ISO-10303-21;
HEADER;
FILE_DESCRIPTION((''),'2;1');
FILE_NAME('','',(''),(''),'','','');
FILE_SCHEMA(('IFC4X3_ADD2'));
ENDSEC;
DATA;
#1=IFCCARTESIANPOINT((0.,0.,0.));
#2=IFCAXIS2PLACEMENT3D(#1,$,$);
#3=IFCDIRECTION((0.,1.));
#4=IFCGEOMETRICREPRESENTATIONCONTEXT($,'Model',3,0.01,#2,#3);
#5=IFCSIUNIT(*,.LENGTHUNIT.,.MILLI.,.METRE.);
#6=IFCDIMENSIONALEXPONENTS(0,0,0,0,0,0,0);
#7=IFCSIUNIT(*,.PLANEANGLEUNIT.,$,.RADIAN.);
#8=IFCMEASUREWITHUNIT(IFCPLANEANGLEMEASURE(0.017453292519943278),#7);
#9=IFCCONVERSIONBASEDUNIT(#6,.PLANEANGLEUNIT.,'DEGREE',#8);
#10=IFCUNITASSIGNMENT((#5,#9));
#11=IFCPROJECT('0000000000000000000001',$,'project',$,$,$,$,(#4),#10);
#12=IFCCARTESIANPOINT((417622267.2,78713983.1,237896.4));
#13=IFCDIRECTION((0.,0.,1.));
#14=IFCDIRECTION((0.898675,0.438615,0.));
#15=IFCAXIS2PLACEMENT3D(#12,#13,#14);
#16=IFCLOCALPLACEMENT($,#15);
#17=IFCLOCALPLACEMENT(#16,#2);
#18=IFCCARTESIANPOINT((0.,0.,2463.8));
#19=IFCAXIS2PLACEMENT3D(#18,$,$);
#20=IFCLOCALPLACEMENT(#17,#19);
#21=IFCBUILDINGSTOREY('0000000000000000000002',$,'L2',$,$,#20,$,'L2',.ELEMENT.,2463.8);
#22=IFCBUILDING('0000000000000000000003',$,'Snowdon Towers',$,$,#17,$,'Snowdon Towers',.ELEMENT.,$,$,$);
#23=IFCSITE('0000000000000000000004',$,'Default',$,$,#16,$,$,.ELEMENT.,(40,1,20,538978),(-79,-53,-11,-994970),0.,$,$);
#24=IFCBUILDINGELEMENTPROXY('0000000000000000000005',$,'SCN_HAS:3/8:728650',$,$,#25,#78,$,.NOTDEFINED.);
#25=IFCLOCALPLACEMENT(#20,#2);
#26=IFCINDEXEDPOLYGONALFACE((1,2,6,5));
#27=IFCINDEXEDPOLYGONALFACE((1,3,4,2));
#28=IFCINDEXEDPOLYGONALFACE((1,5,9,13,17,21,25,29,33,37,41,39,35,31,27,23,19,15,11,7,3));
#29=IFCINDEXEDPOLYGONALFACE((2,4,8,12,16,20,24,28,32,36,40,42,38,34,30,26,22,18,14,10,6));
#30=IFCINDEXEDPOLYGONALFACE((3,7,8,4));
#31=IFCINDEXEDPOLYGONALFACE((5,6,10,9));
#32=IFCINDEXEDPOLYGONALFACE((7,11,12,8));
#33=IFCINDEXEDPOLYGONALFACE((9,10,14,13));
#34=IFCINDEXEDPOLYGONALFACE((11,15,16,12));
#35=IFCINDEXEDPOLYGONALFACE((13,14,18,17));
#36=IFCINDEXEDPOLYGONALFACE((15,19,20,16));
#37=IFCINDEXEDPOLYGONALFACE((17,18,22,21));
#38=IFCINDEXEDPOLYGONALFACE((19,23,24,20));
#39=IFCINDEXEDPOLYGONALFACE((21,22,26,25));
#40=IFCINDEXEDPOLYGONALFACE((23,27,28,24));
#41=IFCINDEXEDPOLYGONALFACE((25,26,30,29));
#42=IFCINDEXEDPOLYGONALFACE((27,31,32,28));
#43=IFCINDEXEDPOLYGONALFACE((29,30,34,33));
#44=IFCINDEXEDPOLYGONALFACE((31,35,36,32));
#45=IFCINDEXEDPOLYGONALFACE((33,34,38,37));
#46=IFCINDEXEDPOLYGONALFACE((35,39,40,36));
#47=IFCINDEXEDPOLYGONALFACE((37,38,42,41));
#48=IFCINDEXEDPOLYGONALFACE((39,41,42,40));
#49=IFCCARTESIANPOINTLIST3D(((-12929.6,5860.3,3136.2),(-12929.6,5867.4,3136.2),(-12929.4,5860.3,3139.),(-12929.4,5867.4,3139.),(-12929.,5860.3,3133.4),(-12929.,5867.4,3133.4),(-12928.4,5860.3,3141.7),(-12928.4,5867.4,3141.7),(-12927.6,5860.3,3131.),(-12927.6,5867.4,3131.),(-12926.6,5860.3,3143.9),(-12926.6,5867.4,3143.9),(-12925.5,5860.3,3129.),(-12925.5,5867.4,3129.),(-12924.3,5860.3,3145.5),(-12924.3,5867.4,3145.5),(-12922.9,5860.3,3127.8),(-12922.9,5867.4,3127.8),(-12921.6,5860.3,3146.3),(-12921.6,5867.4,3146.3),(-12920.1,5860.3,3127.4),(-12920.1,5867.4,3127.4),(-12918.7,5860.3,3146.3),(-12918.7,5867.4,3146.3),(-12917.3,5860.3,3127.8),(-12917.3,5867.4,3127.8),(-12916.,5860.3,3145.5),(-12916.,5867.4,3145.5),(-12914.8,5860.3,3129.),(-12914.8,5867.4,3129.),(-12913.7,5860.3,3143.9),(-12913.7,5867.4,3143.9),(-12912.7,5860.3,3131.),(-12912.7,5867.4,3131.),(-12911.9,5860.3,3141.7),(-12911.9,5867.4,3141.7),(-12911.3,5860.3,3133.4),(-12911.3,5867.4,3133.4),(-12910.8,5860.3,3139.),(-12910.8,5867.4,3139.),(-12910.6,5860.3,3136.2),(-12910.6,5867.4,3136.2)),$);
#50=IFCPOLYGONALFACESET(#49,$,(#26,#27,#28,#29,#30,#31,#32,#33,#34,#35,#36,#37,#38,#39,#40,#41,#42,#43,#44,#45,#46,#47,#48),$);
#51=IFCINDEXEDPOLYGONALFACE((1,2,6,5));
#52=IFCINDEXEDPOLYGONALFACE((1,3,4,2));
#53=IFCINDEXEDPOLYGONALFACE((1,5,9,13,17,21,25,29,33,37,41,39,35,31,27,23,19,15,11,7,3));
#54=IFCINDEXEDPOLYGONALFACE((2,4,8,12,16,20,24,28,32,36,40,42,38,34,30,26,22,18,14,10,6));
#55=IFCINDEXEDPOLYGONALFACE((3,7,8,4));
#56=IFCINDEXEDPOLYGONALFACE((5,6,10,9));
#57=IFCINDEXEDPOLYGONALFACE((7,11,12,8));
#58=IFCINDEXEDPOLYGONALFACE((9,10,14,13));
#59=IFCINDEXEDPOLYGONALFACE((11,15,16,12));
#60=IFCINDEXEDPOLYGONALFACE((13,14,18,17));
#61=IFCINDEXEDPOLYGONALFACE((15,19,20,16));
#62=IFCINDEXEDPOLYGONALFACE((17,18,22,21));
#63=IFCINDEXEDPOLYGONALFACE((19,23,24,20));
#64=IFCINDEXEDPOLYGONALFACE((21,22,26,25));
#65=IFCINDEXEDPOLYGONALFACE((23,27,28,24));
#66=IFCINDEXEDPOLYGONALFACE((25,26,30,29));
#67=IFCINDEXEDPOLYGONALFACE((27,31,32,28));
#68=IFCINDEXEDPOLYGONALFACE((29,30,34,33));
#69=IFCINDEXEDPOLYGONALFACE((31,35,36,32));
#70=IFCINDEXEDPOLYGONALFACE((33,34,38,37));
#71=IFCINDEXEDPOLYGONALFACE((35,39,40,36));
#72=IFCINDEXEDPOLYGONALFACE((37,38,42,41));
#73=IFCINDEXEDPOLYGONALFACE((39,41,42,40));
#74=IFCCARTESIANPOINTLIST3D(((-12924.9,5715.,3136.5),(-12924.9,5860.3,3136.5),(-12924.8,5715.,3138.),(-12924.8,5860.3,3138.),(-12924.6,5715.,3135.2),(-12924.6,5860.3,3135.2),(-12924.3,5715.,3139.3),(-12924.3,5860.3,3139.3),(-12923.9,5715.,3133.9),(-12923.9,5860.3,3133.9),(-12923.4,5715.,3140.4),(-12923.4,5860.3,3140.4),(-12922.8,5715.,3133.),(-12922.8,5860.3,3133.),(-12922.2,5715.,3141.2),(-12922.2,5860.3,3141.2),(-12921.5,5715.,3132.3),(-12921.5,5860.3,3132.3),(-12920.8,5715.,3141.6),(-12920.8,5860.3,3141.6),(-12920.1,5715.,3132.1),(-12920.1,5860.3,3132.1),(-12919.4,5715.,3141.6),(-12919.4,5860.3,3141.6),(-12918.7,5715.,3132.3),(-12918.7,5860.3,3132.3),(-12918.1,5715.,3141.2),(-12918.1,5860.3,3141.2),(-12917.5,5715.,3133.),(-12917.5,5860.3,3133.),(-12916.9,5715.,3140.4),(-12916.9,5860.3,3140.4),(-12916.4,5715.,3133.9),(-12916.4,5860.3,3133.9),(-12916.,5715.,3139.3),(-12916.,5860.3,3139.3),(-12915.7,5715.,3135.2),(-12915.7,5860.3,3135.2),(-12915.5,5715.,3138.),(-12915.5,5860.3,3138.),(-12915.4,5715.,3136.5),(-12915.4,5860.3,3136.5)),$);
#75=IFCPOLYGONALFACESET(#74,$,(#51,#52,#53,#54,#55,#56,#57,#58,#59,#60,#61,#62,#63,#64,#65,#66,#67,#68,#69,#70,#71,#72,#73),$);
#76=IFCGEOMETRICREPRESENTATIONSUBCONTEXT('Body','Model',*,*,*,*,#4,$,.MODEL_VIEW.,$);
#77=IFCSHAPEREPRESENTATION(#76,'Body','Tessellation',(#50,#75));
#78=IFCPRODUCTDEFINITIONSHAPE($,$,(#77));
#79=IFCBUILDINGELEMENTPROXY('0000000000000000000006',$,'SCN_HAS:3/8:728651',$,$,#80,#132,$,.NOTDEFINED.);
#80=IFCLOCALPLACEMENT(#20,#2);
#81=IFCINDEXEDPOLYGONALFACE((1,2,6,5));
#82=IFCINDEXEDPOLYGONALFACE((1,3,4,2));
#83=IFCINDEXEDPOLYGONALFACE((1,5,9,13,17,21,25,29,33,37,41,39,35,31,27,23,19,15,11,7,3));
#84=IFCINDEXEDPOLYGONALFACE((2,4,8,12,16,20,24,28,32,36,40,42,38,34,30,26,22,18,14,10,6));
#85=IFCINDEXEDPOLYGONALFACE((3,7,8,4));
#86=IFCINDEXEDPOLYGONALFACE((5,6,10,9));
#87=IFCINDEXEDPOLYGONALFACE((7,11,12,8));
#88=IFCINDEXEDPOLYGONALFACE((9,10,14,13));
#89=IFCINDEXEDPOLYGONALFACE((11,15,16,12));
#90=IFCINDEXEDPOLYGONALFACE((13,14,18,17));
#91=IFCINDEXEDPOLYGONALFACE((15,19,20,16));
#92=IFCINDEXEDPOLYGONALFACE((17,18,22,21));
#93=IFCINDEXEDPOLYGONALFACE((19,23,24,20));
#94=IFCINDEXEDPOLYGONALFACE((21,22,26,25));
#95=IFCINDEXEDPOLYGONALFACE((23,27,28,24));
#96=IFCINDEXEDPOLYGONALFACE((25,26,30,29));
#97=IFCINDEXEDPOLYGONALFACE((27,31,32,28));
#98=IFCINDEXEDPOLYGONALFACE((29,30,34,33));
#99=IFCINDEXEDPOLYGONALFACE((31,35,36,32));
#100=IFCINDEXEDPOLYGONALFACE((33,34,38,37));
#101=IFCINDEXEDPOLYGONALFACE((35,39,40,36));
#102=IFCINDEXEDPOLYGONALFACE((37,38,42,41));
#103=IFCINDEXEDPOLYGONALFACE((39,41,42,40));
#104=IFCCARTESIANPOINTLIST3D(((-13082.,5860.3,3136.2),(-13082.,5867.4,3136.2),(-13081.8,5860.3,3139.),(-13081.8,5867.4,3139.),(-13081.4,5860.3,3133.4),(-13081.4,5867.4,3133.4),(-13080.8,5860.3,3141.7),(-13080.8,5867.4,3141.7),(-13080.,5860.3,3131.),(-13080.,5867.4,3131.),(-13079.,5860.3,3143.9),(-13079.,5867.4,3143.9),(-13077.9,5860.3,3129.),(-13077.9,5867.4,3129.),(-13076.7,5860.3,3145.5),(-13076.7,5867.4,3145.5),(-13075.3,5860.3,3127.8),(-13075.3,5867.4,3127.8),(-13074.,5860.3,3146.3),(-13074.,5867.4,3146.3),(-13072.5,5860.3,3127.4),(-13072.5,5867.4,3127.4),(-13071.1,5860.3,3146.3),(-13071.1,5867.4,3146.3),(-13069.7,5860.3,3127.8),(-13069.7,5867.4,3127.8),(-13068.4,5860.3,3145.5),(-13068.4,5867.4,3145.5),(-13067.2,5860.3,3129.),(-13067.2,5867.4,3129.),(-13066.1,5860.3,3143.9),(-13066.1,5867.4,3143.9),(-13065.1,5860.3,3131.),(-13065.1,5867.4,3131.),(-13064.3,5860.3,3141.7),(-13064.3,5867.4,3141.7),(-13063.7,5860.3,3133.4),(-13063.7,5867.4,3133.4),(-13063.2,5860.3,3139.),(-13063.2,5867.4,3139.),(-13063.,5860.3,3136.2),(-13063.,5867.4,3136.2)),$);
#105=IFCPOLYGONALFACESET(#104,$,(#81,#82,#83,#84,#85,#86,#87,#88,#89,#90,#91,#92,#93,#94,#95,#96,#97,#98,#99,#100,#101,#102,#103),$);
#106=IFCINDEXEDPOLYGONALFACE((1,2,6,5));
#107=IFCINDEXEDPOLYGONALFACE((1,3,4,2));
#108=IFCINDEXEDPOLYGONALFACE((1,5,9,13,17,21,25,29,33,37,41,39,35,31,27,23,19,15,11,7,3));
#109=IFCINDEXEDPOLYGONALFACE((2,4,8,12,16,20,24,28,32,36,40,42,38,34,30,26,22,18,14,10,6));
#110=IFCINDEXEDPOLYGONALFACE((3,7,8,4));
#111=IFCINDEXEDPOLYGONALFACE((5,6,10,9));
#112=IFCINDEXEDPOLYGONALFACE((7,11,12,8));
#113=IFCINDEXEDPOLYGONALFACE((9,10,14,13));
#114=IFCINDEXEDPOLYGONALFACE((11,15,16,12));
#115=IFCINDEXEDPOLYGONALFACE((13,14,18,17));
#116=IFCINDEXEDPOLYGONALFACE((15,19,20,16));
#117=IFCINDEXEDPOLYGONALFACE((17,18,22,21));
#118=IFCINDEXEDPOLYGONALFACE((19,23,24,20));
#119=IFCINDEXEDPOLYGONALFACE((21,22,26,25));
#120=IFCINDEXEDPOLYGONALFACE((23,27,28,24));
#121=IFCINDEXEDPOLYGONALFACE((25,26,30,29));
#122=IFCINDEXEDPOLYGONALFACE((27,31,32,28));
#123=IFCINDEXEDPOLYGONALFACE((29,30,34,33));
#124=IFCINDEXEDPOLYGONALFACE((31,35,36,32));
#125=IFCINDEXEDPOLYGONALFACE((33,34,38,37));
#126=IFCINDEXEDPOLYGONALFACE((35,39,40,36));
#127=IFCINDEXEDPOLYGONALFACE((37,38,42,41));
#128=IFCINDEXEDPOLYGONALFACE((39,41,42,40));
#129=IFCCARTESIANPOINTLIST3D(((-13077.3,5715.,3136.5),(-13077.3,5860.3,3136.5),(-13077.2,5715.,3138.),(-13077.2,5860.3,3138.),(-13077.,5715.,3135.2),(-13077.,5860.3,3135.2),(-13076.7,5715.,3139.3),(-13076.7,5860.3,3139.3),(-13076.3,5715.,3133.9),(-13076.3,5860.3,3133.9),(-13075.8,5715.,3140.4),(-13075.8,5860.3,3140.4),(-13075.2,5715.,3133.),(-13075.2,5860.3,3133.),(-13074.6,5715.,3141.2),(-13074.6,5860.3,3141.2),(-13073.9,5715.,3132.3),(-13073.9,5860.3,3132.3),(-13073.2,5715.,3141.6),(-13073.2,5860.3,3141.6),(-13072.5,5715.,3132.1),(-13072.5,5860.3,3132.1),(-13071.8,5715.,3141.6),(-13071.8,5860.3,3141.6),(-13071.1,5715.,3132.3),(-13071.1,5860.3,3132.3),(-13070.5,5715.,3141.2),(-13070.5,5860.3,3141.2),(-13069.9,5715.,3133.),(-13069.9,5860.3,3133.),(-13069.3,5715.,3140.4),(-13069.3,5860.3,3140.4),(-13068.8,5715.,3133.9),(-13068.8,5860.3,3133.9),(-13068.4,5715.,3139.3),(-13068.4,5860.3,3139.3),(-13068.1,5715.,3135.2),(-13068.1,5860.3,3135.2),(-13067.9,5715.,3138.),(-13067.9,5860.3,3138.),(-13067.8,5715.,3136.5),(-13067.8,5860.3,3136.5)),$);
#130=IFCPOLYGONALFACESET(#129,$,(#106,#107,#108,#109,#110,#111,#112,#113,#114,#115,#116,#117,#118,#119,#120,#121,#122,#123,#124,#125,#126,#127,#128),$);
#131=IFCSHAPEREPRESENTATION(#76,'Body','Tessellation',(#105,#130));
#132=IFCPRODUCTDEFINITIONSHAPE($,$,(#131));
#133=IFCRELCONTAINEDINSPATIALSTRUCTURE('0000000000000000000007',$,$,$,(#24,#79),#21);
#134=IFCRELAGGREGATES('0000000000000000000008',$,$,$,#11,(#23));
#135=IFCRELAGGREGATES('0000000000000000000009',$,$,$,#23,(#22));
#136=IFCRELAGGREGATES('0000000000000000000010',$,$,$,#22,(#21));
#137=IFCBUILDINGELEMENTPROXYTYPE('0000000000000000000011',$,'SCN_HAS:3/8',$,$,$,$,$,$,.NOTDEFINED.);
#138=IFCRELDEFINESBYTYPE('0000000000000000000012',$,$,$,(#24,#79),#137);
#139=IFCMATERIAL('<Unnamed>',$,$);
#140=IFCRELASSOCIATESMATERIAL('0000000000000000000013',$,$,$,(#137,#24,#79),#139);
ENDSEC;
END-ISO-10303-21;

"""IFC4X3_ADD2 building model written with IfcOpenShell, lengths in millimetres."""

from ifc_helpers import new_model, entity, si_unit, converted_unit, direction, frame, frame_2d, origin, place, context, subcontext, project, spatial, circle, extrude, source, transform, mapped, material, type_object, type_shapes, element, save


model = new_model("IFC4X3_ADD2")

# Units and contexts
model_context = context("Model", 3, precision=0.01, world=origin(), true_north=direction((0.0, 1.0)))
body_context = subcontext(model_context, "Body", "Model", "MODEL_VIEW")
ifc_project = project(units=[si_unit("LENGTHUNIT", "METRE", prefix="MILLI"), converted_unit("PLANEANGLEUNIT", "DEGREE", entity("IfcPlaneAngleMeasure", 0.017453292519943278), si_unit("PLANEANGLEUNIT", "RADIAN"), dimensions=[0, 0, 0, 0, 0, 0, 0])], contexts=[model_context])

# Site, building, storey
site_placement = place(None, frame((417622267.2, 78713983.1, 237896.4), z_axis=(0.0, 0.0, 1.0), x_axis=(0.898675, 0.438615, 0.0)))
site = spatial("IfcSite", under=ifc_project, at=site_placement, Name="Default", CompositionType="ELEMENT", RefLatitude=(40, 1, 20, 538978), RefLongitude=(-79, -53, -11, -994970), RefElevation=0.0)
building_placement = place(site_placement, origin())
building = spatial("IfcBuilding", under=site, at=building_placement, Name="Snowdon Towers", LongName="Snowdon Towers", CompositionType="ELEMENT")
storey_placement = place(building_placement, frame((0.0, 0.0, 2463.8)))
storey = spatial("IfcBuildingStorey", under=building, at=storey_placement, Name="L2", LongName="L2", CompositionType="ELEMENT", Elevation=2463.8)

# Building element proxies
ifc_material_1 = material(Name="<Unnamed>")
building_element_proxy_type_1 = type_object("IfcBuildingElementProxyType", Name="SCN_HAS:3/8", PredefinedType="NOTDEFINED", material=ifc_material_1)
shared_shape_1 = source(origin(), body_context, "Body", "SweptSolid", [
    extrude(circle(Radius=9.5, at=frame_2d((0.0, 0.0), x_axis=(1.0, 0.0))), frame((0.0, 0.0, -152.4), z_axis=(0.0, 0.0, 1.0), x_axis=(0.0, -1.0, 0.0)), (0.0, 0.0, 1.0), 7.1),
    extrude(circle(Radius=4.8, at=frame_2d((0.0, 0.0), x_axis=(1.0, 0.0))), frame((0.0, 0.0, -145.3), z_axis=(0.0, 0.0, 1.0), x_axis=(0.0, -1.0, 0.0)), (0.0, 0.0, 1.0), 145.3),
])
type_shapes(building_element_proxy_type_1, [shared_shape_1])
for number, where, z_axis, x_axis, name in (
    (1, (-12920.1, 5715.0, 3136.9), (0.0, -1.0, 0.0), (1.0, 0.0, 0.0), "SCN_HAS:3/8:728650"),
    (2, (-13072.5, 5715.0, 3136.9), (0.0, -1.0, 0.0), (1.0, 0.0, 0.0), "SCN_HAS:3/8:728651"),
):
    element("IfcBuildingElementProxy", number, at=place(storey_placement, frame(where, z_axis=z_axis, x_axis=x_axis)), inside=storey, type_object=building_element_proxy_type_1, material=ifc_material_1, Name=name, PredefinedType="NOTDEFINED", context=body_context, shape_type="MappedRepresentation", body=[
        mapped(shared_shape_1, transform((0.0, 0.0, 0.0), scale=1.0)),
    ])

save(model, "model.ifc")
